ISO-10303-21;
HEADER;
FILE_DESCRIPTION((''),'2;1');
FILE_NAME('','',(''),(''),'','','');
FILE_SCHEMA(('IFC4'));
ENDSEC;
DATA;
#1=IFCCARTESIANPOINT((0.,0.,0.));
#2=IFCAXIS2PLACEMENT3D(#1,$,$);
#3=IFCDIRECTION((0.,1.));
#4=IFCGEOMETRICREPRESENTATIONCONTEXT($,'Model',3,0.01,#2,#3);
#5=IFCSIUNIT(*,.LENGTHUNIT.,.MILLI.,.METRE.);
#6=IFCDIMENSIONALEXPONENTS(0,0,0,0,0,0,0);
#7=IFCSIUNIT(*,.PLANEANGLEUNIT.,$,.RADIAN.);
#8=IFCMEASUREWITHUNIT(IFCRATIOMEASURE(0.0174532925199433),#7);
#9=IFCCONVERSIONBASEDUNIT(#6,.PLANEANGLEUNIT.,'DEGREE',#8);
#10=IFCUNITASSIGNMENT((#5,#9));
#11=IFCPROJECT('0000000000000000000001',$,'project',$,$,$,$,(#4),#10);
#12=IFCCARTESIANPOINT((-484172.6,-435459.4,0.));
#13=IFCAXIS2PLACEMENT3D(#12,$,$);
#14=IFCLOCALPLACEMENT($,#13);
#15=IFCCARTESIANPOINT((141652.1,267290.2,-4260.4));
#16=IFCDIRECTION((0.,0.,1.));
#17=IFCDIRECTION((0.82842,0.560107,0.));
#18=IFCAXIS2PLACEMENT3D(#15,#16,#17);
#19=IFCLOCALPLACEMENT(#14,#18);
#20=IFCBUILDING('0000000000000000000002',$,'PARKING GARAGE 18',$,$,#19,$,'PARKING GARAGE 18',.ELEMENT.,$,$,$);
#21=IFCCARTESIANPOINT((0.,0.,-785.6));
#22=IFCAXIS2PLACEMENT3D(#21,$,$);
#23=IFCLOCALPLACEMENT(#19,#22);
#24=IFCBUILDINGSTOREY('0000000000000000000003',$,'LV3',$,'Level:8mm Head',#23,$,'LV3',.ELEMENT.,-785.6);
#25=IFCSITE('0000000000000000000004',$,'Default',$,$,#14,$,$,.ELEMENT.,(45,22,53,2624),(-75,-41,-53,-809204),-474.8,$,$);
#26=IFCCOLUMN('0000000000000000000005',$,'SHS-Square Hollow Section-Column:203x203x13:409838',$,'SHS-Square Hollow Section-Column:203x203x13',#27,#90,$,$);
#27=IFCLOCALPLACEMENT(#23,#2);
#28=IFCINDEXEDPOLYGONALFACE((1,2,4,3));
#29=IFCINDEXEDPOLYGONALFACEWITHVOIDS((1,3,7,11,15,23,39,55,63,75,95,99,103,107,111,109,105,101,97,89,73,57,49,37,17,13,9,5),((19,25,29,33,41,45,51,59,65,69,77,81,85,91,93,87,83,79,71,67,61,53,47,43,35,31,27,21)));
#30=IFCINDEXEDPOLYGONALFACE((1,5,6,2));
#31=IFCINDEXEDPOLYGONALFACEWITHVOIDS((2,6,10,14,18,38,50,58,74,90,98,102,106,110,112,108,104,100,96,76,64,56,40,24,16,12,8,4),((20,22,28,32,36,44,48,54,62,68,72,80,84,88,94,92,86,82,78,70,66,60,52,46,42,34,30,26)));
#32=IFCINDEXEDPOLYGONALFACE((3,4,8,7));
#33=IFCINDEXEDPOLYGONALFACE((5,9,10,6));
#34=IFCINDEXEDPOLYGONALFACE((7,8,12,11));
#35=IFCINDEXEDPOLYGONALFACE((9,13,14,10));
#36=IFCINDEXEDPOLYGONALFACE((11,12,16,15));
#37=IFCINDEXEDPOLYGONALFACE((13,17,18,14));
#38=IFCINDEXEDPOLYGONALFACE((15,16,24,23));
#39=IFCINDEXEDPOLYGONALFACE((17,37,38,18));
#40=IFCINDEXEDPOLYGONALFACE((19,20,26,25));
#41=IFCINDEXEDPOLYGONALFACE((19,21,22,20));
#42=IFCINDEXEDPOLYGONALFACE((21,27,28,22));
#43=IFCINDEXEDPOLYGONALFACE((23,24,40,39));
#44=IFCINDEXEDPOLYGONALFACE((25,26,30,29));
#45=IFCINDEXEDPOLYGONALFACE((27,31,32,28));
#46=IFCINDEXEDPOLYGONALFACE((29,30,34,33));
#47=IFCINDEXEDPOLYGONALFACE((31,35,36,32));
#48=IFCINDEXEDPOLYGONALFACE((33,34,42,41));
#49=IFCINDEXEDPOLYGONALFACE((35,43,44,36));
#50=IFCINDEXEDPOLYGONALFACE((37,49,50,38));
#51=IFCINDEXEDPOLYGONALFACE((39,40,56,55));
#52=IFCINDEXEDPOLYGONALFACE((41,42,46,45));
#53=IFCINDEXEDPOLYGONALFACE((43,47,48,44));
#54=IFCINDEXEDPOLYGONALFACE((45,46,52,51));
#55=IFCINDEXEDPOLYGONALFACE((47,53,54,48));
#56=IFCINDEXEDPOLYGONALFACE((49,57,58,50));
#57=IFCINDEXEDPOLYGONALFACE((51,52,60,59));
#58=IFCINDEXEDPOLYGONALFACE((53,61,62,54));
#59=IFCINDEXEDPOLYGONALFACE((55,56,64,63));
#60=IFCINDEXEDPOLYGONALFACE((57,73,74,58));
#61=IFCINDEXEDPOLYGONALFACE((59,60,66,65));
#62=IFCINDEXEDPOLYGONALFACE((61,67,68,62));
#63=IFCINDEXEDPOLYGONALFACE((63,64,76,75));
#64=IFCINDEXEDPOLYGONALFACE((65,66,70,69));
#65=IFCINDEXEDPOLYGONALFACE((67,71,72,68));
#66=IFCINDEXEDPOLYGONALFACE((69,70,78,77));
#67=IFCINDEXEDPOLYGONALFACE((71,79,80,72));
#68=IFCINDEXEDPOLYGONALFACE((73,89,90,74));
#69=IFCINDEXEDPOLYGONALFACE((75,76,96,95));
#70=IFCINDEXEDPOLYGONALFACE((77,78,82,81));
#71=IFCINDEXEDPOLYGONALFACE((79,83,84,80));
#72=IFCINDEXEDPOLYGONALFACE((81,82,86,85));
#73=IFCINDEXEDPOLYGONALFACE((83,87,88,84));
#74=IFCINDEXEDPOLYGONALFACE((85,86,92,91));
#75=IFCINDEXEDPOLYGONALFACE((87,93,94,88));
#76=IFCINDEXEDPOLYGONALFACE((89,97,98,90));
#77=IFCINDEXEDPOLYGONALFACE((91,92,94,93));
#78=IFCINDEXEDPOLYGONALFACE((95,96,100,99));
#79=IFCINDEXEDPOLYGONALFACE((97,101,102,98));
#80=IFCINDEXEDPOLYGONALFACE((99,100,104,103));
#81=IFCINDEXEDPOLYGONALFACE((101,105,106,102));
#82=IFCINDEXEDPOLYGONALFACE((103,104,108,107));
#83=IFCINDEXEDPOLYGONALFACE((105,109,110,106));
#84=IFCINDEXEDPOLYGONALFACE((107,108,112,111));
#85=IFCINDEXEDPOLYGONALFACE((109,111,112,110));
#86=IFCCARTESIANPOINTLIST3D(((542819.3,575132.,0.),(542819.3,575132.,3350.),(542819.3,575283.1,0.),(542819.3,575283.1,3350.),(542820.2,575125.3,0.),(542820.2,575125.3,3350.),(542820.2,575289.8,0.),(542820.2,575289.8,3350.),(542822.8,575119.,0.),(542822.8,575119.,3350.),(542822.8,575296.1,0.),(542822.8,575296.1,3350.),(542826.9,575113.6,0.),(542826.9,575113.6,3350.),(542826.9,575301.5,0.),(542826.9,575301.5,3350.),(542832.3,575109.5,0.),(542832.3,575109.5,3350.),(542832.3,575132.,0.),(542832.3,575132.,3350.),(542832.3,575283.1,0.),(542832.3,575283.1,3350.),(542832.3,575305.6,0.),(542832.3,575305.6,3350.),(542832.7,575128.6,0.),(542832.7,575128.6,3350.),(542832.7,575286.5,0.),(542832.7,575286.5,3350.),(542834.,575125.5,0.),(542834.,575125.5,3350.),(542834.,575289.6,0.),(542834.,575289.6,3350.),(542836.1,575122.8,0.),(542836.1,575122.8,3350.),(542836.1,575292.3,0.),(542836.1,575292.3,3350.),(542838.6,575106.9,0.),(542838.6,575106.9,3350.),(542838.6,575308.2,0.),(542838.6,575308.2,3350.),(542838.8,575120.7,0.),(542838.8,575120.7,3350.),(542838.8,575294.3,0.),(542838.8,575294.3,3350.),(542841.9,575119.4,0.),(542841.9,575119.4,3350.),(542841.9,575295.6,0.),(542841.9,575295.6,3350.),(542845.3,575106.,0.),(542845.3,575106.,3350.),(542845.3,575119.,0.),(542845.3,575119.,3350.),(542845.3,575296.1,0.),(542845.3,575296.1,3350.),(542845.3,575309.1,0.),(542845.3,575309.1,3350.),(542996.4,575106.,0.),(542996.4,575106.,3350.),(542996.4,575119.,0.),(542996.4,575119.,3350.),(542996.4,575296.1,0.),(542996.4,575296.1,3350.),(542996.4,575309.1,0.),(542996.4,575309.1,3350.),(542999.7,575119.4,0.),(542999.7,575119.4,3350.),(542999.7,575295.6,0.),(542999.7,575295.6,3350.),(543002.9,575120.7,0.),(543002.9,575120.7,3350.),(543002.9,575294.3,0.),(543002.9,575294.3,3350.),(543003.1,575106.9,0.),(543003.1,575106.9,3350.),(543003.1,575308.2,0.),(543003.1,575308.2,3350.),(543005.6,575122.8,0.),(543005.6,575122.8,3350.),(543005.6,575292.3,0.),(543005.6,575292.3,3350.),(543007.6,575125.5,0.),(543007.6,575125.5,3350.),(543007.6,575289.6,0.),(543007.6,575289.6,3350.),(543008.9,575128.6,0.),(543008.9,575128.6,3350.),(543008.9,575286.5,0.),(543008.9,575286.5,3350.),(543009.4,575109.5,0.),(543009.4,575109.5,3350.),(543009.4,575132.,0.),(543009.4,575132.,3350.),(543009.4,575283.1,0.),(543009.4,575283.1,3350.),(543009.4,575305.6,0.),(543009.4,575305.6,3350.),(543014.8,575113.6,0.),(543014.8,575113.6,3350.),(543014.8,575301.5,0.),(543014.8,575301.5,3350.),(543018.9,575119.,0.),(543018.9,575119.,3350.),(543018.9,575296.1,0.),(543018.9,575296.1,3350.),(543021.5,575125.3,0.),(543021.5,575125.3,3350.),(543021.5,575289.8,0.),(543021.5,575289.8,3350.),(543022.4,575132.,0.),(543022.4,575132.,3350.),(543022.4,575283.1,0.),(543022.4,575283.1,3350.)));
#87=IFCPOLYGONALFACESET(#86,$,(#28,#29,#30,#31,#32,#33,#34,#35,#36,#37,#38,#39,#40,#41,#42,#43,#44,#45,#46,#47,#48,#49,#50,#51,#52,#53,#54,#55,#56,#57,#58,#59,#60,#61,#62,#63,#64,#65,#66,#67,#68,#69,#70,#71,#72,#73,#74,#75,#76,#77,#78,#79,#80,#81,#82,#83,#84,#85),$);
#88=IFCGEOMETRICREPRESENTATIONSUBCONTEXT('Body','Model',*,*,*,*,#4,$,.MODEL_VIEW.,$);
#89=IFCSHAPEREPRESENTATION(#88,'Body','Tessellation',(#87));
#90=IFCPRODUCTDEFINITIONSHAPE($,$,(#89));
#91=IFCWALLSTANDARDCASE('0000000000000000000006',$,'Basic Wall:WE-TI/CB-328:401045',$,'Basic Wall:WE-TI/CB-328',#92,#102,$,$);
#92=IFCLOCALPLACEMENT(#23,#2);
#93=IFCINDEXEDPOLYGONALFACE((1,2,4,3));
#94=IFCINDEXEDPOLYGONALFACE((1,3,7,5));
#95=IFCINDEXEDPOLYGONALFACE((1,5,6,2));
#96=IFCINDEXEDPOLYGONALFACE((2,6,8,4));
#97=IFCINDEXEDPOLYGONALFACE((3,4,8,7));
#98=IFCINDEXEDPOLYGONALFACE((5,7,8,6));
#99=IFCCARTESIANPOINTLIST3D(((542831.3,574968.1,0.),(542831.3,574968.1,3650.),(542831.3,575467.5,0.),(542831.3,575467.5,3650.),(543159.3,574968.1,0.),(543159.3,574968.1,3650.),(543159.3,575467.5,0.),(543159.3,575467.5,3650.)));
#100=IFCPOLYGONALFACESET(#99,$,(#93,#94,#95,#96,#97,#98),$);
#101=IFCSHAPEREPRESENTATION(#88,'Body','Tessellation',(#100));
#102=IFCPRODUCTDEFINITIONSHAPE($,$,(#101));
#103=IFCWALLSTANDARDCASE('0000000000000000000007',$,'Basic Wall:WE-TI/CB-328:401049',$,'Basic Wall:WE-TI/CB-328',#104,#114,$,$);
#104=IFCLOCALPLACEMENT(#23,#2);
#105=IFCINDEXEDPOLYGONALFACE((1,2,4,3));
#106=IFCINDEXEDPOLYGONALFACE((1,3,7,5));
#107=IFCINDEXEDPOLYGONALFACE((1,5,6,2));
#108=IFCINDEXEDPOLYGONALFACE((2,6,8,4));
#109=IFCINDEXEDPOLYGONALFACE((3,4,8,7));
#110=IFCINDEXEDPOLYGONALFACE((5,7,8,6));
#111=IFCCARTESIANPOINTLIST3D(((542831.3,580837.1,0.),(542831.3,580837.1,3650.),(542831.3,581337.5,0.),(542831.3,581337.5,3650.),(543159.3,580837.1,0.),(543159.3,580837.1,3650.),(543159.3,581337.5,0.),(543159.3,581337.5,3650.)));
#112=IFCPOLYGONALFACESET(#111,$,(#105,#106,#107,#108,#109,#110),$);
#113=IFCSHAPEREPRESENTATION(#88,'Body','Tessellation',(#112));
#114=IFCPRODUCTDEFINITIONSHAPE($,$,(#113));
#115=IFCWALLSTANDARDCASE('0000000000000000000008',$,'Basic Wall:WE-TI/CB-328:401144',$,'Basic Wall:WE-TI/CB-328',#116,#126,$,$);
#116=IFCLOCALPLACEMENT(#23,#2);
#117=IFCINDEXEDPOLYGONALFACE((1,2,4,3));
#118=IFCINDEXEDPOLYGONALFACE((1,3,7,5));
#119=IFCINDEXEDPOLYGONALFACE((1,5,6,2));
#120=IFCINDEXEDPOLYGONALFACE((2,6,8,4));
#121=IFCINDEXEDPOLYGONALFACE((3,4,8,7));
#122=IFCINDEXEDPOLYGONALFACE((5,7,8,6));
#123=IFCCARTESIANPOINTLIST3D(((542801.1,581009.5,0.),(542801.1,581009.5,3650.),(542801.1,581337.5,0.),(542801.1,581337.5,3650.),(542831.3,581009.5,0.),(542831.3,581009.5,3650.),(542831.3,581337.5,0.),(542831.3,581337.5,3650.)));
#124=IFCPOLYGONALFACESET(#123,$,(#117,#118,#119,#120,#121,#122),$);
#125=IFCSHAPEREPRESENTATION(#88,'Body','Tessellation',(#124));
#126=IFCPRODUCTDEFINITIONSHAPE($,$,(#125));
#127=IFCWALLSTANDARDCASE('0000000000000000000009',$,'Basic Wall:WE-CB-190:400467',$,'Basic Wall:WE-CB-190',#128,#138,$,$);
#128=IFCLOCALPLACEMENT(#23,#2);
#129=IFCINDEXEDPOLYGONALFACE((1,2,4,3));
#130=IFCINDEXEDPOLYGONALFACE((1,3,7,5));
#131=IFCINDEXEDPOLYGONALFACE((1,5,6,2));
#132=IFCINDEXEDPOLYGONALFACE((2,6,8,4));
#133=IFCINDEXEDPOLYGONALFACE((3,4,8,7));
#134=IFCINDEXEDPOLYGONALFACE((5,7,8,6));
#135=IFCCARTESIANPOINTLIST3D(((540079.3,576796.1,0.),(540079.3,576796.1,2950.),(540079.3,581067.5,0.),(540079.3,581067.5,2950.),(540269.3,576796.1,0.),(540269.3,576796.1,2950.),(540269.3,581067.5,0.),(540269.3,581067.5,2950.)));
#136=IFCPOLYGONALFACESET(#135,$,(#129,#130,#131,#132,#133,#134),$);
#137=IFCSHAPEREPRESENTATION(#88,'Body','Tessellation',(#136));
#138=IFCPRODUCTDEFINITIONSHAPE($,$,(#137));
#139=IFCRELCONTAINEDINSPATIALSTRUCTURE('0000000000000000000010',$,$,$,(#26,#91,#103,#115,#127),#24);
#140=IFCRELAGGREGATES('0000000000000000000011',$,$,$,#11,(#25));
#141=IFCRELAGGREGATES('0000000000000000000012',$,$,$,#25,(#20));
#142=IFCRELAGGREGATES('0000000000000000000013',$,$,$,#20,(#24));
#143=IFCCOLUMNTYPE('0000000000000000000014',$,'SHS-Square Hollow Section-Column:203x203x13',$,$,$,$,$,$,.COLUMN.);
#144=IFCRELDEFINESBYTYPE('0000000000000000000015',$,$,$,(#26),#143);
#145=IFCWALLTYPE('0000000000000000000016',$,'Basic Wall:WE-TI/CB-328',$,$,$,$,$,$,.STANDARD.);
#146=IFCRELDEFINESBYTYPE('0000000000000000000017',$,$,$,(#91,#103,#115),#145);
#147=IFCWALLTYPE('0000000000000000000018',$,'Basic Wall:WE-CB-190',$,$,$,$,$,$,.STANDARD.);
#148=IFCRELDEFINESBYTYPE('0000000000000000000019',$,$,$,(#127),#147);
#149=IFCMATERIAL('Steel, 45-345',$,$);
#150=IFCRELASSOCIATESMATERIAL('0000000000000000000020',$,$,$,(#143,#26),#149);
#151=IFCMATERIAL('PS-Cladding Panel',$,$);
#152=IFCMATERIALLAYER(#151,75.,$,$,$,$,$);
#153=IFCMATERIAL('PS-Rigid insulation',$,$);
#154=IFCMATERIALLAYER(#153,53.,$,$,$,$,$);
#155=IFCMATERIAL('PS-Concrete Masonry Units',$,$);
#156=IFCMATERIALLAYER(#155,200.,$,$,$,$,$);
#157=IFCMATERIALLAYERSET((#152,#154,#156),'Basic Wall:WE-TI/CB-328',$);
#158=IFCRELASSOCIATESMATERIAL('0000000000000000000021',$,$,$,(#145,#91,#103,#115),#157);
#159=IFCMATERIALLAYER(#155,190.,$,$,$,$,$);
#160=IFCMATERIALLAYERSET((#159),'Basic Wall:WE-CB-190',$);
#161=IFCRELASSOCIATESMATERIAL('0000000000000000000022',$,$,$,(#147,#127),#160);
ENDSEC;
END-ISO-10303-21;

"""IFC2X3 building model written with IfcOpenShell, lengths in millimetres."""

from ifc_helpers import new_model, entity, si_unit, converted_unit, direction, frame, frame_2d, origin, place, context, subcontext, project, spatial, polyline, circle_curve, parameter, trimmed, segment, composite_curve, rectangle, outline, extrude, source, transform, mapped, material, layer, layer_set, layer_usage, type_object, type_shapes, element, save


model = new_model("IFC2X3")

# Units and contexts
model_context = context("Model", 3, precision=0.01, world=origin(), true_north=direction((0.0, 1.0)))
body_context = subcontext(model_context, "Body", "Model", "MODEL_VIEW")
ifc_project = project(units=[si_unit("LENGTHUNIT", "METRE", prefix="MILLI"), converted_unit("PLANEANGLEUNIT", "DEGREE", entity("IfcRatioMeasure", 0.0174532925199433), si_unit("PLANEANGLEUNIT", "RADIAN"), dimensions=[0, 0, 0, 0, 0, 0, 0])], contexts=[model_context])

# Site, building, storey
site_placement = place(None, frame((-484172.6, -435459.4, 0.0)))
site = spatial("IfcSite", under=ifc_project, at=site_placement, Name="Default", CompositionType="ELEMENT", RefLatitude=(45, 22, 53, 2624), RefLongitude=(-75, -41, -53, -809204), RefElevation=-474.8)
building_placement = place(site_placement, frame((141652.1, 267290.2, -4260.4), z_axis=(0.0, 0.0, 1.0), x_axis=(0.82842, 0.560107, 0.0)))
building = spatial("IfcBuilding", under=site, at=building_placement, Name="PARKING GARAGE 18", LongName="PARKING GARAGE 18", CompositionType="ELEMENT")
storey_placement = place(building_placement, frame((0.0, 0.0, -785.6)))
storey = spatial("IfcBuildingStorey", under=building, at=storey_placement, Name="LV3", ObjectType="Level:8mm Head", LongName="LV3", CompositionType="ELEMENT", Elevation=-785.6)

# Column
ifc_material_1 = material(Name="Steel, 45-345")
column_type = type_object("IfcColumnType", Name="SHS-Square Hollow Section-Column:203x203x13", PredefinedType="COLUMN", material=ifc_material_1)
shared_shape_1 = source(origin(), body_context, "Body", "SweptSolid", [
    extrude(outline(composite_curve([segment(polyline([(-75.6, -101.5), (75.6, -101.5)]), True, "CONTINUOUS"), segment(trimmed(circle_curve(frame_2d((75.6, -75.6), x_axis=(-1.0, 0.0)), 26.0), [parameter(90.0)], [parameter(180.0)], True, "PARAMETER"), True, "CONTINUOUS"), segment(polyline([(101.5, -75.6), (101.5, 75.6)]), True, "CONTINUOUS"), segment(trimmed(circle_curve(frame_2d((75.5, 75.6), x_axis=(-1.0, 0.0)), 26.0), [parameter(180.0)], [parameter(270.0)], True, "PARAMETER"), True, "CONTINUOUS"), segment(polyline([(75.5, 101.6), (-75.5, 101.6)]), True, "CONTINUOUS"), segment(trimmed(circle_curve(frame_2d((-75.5, 75.5), x_axis=(-1.0, 0.0)), 26.0), [parameter(270.0)], [parameter(360.0)], True, "PARAMETER"), True, "CONTINUOUS"), segment(polyline([(-101.5, 75.5), (-101.5, -75.6)]), True, "CONTINUOUS"), segment(trimmed(circle_curve(frame_2d((-75.6, -75.6), x_axis=(-1.0, 0.0)), 26.0), [parameter(360.0)], [parameter(90.0)], True, "PARAMETER"), True, "CONTINUOUS")], self_intersect=False), holes=[composite_curve([segment(trimmed(circle_curve(frame_2d((-75.6, -75.6), x_axis=(-1.0, 0.0)), 13.0), [parameter(0.0)], [parameter(90.0)], True, "PARAMETER"), False, "CONTINUOUS"), segment(polyline([(-88.5, -75.6), (-88.5, 75.6)]), True, "CONTINUOUS"), segment(trimmed(circle_curve(frame_2d((-75.6, 75.6), x_axis=(-1.0, 0.0)), 13.0), [parameter(270.0)], [parameter(0.0)], True, "PARAMETER"), False, "CONTINUOUS"), segment(polyline([(-75.6, 88.6), (75.5, 88.6)]), True, "CONTINUOUS"), segment(trimmed(circle_curve(frame_2d((75.5, 75.5), x_axis=(-1.0, 0.0)), 13.0), [parameter(180.0)], [parameter(270.0)], True, "PARAMETER"), False, "CONTINUOUS"), segment(polyline([(88.6, 75.5), (88.6, -75.5)]), True, "CONTINUOUS"), segment(trimmed(circle_curve(frame_2d((75.6, -75.5), x_axis=(-1.0, 0.0)), 13.0), [parameter(90.0)], [parameter(180.0)], True, "PARAMETER"), False, "CONTINUOUS"), segment(polyline([(75.6, -88.5), (-75.6, -88.5)]), True, "CONTINUOUS")], self_intersect=False)]), frame((0.0, 0.0, -785.6), z_axis=(0.0, 0.0, 1.0), x_axis=(-1.0, 0.0, 0.0)), (0.0, 0.0, 1.0), 3350.0),
])
type_shapes(column_type, [shared_shape_1])
for number, where, name in (
    (1, (542920.8, 575207.5, 785.6), "SHS-Square Hollow Section-Column:203x203x13:409838"),
):
    element("IfcColumn", number, at=place(storey_placement, frame(where)), inside=storey, type_object=column_type, material=ifc_material_1, Name=name, ObjectType="SHS-Square Hollow Section-Column:203x203x13", context=body_context, shape_type="MappedRepresentation", body=[
        mapped(shared_shape_1, transform((0.0, 0.0, 0.0), scale=1.0)),
    ])

# Walls
ifc_material_2 = material(Name="PS-Cladding Panel")
ifc_layer_1 = layer(ifc_material_2, 75.0)
ifc_material_3 = material(Name="PS-Rigid insulation")
ifc_layer_2 = layer(ifc_material_3, 53.0)
ifc_material_4 = material(Name="PS-Concrete Masonry Units")
ifc_layer_3 = layer(ifc_material_4, 200.0)
ifc_layer_set_1 = layer_set([ifc_layer_1, ifc_layer_2, ifc_layer_3], Name="Basic Wall:WE-TI/CB-328")
ifc_layer_usage_1 = layer_usage(ifc_layer_set_1, "AXIS2", "NEGATIVE", 164.0)
wall_type_1 = type_object("IfcWallType", Name="Basic Wall:WE-TI/CB-328", PredefinedType="STANDARD", material=ifc_layer_set_1)
wall_1_placement = place(storey_placement, frame((542995.3, 575467.5, 0.0), z_axis=(0.0, 0.0, 1.0), x_axis=(0.0, -1.0, 0.0)))
element("IfcWallStandardCase", 2, at=wall_1_placement, inside=storey, type_object=wall_type_1, material=ifc_layer_usage_1, Name="Basic Wall:WE-TI/CB-328:401045", ObjectType="Basic Wall:WE-TI/CB-328", context=body_context, shape_type="SweptSolid", body=[
    extrude(rectangle(XDim=499.5, YDim=328.0, at=frame_2d((249.7, 0.0), x_axis=(-1.0, 0.0))), origin(), (0.0, 0.0, 1.0), 3650.0),
])
ifc_layer_usage_2 = layer_usage(ifc_layer_set_1, "AXIS2", "NEGATIVE", 164.0)
wall_2_placement = place(storey_placement, frame((542995.3, 581337.5, 0.0), z_axis=(0.0, 0.0, 1.0), x_axis=(0.0, -1.0, 0.0)))
element("IfcWallStandardCase", 3, at=wall_2_placement, inside=storey, type_object=wall_type_1, material=ifc_layer_usage_2, Name="Basic Wall:WE-TI/CB-328:401049", ObjectType="Basic Wall:WE-TI/CB-328", context=body_context, shape_type="SweptSolid", body=[
    extrude(rectangle(XDim=500.4, YDim=328.0, at=frame_2d((250.2, 0.0), x_axis=(-1.0, 0.0))), origin(), (0.0, 0.0, 1.0), 3650.0),
])
ifc_layer_usage_3 = layer_usage(ifc_layer_set_1, "AXIS2", "NEGATIVE", 164.0)
wall_3_placement = place(storey_placement, frame((542801.1, 581173.5, 0.0)))
element("IfcWallStandardCase", 4, at=wall_3_placement, inside=storey, type_object=wall_type_1, material=ifc_layer_usage_3, Name="Basic Wall:WE-TI/CB-328:401144", ObjectType="Basic Wall:WE-TI/CB-328", context=body_context, shape_type="SweptSolid", body=[
    extrude(rectangle(XDim=30.2, YDim=328.0, at=frame_2d((15.1, 0.0), x_axis=(-1.0, 0.0))), origin(), (0.0, 0.0, 1.0), 3650.0),
])
ifc_layer_4 = layer(ifc_material_4, 190.0)
ifc_layer_set_2 = layer_set([ifc_layer_4], Name="Basic Wall:WE-CB-190")
ifc_layer_usage_4 = layer_usage(ifc_layer_set_2, "AXIS2", "NEGATIVE", 95.0)
wall_type_2 = type_object("IfcWallType", Name="Basic Wall:WE-CB-190", PredefinedType="STANDARD", material=ifc_layer_set_2)
wall_4_placement = place(storey_placement, frame((540174.3, 581067.5, 0.0), z_axis=(0.0, 0.0, 1.0), x_axis=(0.0, -1.0, 0.0)))
element("IfcWallStandardCase", 5, at=wall_4_placement, inside=storey, type_object=wall_type_2, material=ifc_layer_usage_4, Name="Basic Wall:WE-CB-190:400467", ObjectType="Basic Wall:WE-CB-190", context=body_context, shape_type="SweptSolid", body=[
    extrude(rectangle(XDim=4271.5, YDim=190.0, at=frame_2d((2135.7, 0.0), x_axis=(-1.0, 0.0))), origin(), (0.0, 0.0, 1.0), 2950.0),
])

save(model, "model.ifc")
